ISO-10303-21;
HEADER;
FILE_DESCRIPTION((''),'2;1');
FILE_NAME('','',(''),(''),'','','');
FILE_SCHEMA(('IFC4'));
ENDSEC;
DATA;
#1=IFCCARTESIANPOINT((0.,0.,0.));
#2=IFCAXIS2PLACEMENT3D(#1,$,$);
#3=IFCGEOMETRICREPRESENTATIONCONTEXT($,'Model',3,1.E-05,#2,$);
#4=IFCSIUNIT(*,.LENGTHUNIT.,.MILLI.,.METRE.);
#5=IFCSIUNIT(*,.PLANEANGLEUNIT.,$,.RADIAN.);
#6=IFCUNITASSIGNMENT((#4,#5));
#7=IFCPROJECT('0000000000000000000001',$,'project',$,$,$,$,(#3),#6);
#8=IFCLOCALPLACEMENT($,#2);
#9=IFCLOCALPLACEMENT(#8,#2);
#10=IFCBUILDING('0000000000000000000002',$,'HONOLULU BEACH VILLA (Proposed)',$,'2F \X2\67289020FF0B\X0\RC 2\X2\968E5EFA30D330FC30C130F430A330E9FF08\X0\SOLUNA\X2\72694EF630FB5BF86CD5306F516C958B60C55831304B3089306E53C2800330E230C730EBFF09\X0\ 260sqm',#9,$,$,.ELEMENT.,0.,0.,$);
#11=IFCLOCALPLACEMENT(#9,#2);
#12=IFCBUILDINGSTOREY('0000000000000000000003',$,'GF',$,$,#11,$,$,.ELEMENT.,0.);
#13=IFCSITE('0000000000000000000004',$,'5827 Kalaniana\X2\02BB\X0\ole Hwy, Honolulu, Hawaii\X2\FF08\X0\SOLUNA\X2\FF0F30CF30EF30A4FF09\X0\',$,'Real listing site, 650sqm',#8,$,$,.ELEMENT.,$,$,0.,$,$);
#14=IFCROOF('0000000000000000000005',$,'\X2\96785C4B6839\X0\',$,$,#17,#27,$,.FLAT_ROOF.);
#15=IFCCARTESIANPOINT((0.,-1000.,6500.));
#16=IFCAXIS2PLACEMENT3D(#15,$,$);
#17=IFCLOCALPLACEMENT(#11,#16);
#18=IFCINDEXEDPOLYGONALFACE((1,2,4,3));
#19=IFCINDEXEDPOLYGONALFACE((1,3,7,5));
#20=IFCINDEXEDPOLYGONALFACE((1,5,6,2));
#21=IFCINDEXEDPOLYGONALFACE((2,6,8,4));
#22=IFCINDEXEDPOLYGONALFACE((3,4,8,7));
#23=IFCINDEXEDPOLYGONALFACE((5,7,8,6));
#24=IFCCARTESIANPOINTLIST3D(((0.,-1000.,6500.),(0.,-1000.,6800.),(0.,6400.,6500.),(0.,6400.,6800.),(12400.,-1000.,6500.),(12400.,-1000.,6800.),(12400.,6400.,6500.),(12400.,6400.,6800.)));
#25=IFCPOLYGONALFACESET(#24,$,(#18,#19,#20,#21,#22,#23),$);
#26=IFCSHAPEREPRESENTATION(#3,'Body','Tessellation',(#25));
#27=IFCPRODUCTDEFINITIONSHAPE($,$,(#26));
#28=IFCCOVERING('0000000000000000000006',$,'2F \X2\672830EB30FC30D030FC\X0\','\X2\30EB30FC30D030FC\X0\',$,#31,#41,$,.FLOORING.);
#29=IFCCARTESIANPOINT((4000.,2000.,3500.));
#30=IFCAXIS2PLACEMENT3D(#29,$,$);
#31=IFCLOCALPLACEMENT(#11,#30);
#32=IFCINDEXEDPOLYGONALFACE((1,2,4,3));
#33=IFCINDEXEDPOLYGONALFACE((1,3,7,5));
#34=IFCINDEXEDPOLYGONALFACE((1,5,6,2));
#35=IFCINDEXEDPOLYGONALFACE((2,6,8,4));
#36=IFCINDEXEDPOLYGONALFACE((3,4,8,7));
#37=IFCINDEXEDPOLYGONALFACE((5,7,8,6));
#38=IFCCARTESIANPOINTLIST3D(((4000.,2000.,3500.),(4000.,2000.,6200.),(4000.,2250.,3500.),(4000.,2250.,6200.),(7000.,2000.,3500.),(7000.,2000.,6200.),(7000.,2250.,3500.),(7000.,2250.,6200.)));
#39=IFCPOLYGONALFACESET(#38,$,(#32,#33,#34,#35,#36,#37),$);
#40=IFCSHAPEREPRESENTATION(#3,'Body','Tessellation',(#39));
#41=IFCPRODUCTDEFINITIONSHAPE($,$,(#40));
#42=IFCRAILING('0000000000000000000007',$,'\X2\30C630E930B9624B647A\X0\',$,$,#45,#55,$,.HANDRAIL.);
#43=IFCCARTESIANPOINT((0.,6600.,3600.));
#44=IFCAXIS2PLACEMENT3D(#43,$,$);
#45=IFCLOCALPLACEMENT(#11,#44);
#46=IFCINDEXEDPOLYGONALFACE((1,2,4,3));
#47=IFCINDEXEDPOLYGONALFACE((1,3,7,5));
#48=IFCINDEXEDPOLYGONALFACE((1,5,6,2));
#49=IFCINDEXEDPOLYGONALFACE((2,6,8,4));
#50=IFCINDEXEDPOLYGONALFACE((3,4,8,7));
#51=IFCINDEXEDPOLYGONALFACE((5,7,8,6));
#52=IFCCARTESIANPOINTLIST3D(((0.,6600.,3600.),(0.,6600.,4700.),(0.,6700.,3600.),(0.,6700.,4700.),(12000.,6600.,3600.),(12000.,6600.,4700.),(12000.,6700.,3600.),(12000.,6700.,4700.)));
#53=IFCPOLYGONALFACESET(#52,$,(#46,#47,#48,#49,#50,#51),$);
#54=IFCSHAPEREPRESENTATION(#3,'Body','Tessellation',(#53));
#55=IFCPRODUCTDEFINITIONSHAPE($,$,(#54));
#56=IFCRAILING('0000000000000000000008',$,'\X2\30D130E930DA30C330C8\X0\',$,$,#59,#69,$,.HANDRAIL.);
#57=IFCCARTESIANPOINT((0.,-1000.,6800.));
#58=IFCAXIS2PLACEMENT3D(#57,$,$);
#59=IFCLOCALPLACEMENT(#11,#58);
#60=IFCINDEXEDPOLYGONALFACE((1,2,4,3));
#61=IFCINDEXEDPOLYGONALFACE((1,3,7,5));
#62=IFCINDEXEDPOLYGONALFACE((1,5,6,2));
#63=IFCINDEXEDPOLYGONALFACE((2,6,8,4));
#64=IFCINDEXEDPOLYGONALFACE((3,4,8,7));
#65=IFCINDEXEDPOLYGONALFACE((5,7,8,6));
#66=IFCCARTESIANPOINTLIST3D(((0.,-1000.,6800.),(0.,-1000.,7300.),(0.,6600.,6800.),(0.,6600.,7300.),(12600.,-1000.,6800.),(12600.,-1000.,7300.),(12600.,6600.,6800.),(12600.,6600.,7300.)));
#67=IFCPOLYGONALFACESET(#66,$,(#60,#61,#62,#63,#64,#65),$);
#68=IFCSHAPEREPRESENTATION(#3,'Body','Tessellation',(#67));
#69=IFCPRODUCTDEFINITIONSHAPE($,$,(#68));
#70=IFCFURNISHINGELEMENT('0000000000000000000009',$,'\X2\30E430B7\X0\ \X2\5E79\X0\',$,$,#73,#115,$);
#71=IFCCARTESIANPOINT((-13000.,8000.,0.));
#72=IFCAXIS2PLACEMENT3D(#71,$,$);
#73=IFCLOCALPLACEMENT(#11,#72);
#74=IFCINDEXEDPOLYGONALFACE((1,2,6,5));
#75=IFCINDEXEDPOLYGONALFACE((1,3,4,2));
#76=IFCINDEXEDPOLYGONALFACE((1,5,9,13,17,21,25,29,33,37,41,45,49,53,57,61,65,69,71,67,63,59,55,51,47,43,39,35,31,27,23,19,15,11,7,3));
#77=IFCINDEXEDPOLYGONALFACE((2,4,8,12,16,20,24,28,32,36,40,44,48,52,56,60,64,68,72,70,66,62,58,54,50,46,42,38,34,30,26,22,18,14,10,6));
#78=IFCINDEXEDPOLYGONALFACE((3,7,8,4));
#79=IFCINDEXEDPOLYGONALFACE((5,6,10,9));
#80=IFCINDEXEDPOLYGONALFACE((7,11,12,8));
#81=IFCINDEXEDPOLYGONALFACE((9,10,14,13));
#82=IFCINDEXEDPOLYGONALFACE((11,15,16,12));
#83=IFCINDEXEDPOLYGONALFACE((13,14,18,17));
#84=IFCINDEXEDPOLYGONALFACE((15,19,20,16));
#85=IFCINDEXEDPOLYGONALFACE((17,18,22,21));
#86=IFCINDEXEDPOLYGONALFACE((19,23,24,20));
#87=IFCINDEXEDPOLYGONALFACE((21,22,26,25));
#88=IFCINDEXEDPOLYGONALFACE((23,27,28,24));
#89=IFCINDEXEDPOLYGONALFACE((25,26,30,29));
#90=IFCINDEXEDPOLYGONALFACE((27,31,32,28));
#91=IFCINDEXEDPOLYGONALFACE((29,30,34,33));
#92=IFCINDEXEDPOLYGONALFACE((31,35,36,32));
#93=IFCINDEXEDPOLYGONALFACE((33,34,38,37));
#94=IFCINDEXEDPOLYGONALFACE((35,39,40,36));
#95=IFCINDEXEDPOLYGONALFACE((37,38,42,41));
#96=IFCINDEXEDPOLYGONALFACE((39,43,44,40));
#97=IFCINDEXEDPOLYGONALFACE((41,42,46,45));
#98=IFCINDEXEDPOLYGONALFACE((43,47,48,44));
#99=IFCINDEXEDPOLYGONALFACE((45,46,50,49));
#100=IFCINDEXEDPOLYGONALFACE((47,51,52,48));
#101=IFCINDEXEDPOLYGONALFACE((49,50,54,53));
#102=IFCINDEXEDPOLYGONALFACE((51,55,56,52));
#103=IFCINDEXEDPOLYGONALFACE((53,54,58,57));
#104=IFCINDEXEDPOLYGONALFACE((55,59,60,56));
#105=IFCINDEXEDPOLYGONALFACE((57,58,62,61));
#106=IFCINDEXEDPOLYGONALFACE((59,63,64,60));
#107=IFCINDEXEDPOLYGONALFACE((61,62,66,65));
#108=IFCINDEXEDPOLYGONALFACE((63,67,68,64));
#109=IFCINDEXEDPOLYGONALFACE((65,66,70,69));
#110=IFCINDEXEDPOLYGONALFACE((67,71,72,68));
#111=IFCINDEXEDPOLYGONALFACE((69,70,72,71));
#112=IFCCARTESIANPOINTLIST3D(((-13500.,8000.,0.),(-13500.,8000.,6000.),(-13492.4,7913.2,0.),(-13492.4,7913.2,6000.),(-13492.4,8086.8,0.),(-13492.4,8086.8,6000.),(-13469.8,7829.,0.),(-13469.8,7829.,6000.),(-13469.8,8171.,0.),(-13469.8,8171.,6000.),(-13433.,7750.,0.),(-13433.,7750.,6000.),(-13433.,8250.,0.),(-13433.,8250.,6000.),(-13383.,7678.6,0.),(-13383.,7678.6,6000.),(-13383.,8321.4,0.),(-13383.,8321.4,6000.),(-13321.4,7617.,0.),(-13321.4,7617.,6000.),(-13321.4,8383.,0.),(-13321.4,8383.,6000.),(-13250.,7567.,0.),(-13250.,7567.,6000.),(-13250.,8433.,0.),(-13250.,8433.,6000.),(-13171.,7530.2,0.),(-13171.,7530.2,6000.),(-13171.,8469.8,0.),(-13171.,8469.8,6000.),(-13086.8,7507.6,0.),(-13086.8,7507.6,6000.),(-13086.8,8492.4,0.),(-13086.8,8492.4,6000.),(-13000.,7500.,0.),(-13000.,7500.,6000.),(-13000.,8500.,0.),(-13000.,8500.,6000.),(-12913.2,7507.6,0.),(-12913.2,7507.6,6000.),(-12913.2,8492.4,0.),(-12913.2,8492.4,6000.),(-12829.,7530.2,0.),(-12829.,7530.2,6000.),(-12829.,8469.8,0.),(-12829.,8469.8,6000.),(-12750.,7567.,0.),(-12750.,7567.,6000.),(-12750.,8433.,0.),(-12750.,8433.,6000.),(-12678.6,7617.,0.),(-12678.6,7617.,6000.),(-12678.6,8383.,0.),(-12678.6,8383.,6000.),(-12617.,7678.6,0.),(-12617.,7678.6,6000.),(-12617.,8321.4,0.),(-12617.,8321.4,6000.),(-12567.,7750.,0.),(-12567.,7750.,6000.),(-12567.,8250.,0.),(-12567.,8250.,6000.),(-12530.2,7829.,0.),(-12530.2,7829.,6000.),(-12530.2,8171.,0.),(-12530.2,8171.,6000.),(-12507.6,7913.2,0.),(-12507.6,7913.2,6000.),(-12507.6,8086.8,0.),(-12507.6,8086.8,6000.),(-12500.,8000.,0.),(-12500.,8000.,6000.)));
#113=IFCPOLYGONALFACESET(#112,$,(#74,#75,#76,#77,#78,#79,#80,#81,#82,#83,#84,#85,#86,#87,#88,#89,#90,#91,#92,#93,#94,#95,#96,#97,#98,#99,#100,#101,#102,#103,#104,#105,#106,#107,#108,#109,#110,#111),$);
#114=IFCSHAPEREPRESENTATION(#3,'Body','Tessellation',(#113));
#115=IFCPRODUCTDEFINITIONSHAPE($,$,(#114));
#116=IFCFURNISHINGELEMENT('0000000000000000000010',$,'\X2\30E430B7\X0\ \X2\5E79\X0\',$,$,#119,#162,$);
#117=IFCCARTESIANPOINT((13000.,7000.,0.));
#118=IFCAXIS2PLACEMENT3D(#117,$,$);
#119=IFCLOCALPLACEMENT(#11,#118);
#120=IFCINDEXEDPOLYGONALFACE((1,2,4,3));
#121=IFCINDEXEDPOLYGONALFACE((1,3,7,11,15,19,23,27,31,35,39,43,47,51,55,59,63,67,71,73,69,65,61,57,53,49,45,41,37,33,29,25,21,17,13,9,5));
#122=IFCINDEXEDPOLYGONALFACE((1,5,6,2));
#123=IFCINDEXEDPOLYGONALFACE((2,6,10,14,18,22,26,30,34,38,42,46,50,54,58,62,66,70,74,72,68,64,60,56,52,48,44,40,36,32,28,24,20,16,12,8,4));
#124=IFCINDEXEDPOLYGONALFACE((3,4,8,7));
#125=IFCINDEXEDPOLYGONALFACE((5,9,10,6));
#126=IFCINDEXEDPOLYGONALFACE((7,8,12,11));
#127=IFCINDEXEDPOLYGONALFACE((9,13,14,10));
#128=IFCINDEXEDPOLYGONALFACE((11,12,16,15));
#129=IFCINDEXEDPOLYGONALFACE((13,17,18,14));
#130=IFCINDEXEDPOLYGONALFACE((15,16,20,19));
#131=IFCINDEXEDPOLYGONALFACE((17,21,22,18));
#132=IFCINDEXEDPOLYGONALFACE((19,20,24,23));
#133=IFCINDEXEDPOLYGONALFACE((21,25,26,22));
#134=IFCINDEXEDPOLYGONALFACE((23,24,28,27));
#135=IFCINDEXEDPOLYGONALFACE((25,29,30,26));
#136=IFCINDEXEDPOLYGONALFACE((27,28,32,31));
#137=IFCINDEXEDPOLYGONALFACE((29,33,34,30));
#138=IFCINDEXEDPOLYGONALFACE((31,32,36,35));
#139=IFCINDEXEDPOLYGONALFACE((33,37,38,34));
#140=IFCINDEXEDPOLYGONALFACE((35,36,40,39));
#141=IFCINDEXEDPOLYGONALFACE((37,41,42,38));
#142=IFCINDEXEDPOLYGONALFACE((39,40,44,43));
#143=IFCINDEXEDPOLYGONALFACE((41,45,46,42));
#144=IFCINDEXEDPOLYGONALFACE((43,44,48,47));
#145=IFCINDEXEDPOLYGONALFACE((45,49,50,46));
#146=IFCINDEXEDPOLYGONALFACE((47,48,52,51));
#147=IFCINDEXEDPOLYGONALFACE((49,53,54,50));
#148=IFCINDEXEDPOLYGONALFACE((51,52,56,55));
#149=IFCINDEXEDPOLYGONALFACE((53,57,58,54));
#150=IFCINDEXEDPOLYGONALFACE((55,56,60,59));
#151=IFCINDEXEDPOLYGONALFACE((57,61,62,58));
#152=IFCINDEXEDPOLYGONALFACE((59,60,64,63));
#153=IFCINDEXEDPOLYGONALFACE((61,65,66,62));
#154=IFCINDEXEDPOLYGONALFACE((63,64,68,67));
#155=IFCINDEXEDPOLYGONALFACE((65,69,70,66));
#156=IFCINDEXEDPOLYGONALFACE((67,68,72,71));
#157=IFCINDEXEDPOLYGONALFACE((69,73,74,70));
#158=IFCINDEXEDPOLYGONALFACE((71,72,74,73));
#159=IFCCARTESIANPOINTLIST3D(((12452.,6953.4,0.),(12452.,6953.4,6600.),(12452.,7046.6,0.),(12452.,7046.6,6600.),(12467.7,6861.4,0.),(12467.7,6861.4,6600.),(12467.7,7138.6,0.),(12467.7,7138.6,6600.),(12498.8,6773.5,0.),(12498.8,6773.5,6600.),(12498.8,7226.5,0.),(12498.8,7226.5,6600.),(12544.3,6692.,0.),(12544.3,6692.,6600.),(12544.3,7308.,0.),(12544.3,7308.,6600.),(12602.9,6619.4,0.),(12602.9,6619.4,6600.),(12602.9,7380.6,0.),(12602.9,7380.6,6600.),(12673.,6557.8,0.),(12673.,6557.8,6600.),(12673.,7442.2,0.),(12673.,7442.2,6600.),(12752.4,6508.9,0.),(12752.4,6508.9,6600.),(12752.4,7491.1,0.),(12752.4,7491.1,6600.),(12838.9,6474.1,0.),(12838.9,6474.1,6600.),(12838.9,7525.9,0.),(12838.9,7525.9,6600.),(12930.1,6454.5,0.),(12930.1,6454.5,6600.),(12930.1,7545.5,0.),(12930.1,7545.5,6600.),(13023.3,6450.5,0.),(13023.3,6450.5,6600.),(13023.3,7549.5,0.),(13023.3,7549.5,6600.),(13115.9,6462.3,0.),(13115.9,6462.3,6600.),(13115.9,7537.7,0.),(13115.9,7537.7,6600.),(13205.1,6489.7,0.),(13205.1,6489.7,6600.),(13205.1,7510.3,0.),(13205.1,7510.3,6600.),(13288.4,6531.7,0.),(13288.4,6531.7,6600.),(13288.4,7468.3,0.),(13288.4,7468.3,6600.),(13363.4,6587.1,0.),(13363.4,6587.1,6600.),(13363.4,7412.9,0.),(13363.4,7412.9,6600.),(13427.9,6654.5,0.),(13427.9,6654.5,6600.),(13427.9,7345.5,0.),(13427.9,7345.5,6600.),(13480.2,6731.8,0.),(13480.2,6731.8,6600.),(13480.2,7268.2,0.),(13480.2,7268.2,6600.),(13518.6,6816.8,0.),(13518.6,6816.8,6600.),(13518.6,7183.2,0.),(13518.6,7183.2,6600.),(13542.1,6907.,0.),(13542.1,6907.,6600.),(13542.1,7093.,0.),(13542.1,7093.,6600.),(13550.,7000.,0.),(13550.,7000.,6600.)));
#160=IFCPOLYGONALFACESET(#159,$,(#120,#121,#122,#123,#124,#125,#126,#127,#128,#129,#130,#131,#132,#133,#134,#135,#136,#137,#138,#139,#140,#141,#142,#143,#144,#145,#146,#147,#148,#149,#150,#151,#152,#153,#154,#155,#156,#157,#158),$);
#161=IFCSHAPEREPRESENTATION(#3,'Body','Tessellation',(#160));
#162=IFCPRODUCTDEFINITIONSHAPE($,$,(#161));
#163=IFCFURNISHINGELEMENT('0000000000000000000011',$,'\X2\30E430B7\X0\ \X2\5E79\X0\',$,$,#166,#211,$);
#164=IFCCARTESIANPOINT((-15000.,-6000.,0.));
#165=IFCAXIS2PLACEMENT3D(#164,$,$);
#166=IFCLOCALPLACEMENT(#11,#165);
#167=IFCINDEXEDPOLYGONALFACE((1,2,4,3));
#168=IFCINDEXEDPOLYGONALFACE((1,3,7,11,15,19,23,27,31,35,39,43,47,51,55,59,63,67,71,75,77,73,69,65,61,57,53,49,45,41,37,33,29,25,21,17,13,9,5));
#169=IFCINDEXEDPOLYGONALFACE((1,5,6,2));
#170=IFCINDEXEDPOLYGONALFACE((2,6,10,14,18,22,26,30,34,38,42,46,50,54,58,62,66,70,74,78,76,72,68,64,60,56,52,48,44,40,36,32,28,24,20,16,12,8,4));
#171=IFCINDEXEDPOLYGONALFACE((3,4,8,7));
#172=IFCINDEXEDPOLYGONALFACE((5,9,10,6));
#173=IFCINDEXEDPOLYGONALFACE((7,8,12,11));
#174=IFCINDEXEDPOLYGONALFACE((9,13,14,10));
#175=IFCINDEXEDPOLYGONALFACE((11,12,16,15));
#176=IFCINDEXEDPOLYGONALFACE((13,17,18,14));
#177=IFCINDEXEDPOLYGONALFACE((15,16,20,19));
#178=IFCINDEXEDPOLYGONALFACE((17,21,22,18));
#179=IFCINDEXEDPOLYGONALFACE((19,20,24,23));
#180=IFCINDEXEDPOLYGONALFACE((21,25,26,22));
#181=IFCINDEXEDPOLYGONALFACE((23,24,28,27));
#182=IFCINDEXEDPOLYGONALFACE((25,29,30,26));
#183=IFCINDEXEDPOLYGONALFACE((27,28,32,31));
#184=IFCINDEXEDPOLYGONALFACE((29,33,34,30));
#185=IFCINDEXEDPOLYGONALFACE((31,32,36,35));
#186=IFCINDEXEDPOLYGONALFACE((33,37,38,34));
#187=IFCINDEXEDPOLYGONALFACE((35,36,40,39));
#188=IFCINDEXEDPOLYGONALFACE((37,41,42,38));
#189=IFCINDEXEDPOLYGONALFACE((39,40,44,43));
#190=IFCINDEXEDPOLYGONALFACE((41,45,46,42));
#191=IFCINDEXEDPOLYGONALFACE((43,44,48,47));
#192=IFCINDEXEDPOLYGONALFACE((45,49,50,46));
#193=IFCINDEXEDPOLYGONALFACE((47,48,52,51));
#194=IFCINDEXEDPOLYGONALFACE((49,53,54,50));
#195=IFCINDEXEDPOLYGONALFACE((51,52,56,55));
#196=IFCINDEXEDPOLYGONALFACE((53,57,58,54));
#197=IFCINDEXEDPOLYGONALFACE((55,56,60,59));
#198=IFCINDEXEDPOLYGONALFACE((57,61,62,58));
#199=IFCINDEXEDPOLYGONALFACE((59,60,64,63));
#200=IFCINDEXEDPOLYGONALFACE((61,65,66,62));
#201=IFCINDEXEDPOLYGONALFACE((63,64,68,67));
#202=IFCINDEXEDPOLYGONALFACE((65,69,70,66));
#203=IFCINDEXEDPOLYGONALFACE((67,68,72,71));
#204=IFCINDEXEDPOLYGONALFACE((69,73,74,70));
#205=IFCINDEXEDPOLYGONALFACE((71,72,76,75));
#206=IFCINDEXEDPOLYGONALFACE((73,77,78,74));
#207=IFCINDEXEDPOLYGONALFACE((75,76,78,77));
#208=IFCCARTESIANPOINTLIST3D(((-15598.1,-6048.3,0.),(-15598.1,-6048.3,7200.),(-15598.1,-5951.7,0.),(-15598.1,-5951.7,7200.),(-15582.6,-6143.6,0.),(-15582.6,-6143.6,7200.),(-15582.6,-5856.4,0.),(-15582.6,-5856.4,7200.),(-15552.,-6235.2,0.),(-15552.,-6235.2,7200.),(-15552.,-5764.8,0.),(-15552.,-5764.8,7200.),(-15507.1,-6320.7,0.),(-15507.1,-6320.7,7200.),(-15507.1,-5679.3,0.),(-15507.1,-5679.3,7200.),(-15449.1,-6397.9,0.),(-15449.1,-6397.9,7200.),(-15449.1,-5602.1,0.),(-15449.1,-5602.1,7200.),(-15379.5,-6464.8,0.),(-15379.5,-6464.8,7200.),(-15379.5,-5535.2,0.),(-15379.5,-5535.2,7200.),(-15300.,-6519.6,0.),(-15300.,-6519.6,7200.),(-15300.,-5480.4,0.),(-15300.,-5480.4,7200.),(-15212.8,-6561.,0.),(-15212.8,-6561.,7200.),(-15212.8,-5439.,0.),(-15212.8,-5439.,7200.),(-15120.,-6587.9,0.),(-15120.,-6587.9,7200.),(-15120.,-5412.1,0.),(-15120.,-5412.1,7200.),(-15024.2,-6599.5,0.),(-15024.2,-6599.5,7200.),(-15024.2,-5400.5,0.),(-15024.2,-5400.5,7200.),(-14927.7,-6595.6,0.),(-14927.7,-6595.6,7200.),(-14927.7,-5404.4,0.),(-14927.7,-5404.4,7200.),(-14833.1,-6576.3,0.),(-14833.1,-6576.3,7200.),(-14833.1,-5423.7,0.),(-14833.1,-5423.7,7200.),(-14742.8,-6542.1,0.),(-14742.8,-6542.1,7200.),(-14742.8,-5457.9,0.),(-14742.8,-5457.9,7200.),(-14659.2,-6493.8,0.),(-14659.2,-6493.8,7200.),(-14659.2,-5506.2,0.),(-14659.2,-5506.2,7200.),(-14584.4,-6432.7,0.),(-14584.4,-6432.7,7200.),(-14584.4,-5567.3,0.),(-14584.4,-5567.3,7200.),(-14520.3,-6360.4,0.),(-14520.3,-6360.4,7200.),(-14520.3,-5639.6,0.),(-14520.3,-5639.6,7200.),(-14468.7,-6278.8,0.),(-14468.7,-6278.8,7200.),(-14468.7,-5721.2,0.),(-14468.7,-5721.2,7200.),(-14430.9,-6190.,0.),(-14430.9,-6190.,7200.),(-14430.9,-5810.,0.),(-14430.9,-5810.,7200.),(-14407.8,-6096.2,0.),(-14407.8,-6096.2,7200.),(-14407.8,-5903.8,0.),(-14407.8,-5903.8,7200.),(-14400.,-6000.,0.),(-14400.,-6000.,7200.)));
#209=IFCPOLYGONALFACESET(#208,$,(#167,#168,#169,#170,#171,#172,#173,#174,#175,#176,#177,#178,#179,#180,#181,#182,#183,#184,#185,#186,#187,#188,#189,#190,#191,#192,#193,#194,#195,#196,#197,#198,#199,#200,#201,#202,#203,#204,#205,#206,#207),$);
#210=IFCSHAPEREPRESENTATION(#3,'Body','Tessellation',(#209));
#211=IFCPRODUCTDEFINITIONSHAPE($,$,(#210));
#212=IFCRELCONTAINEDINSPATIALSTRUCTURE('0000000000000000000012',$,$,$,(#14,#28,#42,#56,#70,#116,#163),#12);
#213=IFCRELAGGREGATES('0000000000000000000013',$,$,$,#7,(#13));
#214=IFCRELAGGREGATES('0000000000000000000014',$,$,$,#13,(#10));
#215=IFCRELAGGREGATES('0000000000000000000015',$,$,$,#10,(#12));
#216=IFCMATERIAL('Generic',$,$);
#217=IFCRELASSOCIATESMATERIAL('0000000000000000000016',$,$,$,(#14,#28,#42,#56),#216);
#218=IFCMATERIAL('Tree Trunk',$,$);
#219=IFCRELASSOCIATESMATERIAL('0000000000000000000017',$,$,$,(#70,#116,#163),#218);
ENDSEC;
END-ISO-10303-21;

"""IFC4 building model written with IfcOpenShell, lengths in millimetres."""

from ifc_helpers import new_model, si_unit, frame, frame_2d, origin, origin_2d, place, context, project, spatial, rectangle, circle, extrude, material, element, save


model = new_model("IFC4")

# Units and contexts
model_context = context("Model", 3, precision=1e-05, world=origin())
ifc_project = project(units=[si_unit("LENGTHUNIT", "METRE", prefix="MILLI"), si_unit("PLANEANGLEUNIT", "RADIAN")], contexts=[model_context])

# Site, building, storey
site_placement = place(None, origin())
site = spatial("IfcSite", under=ifc_project, at=site_placement, Name="5827 Kalanianaʻole Hwy, Honolulu, Hawaii（SOLUNA／ハワイ）", ObjectType="Real listing site, 650sqm", CompositionType="ELEMENT", RefElevation=0.0)
building_placement = place(site_placement, origin())
building = spatial("IfcBuilding", under=site, at=building_placement, Name="HONOLULU BEACH VILLA (Proposed)", ObjectType="2F 木造＋RC 2階建ビーチヴィラ（SOLUNA物件・寸法は公開情報からの参考モデル） 260sqm", CompositionType="ELEMENT", ElevationOfRefHeight=0.0, ElevationOfTerrain=0.0)
storey_placement = place(building_placement, origin())
storey = spatial("IfcBuildingStorey", under=building, at=storey_placement, Name="GF", CompositionType="ELEMENT", Elevation=0.0)

# Shared definitions
ifc_material_1 = material(Name="Generic")

# Roof
roof_placement = place(storey_placement, frame((0.0, -1000.0, 6500.0)))
element("IfcRoof", 1, at=roof_placement, inside=storey, material=ifc_material_1, Name="陸屋根", PredefinedType="FLAT_ROOF", context=model_context, shape_type="SweptSolid", body=[
    extrude(rectangle(XDim=12400.0, YDim=7400.0, at=frame_2d((6200.0, 3700.0))), frame((0.0, -1000.0, 6500.0)), (0.0, 0.0, 1.0), 300.0),
])

# Covering
covering_placement = place(storey_placement, frame((4000.0, 2000.0, 3500.0)))
element("IfcCovering", 2, at=covering_placement, inside=storey, material=ifc_material_1, Name="2F 木ルーバー", Description="ルーバー", PredefinedType="FLOORING", context=model_context, shape_type="SweptSolid", body=[
    extrude(rectangle(XDim=3000.0, YDim=250.0, at=frame_2d((1500.0, 125.0))), frame((4000.0, 2000.0, 3500.0)), (0.0, 0.0, 1.0), 2700.0),
])

# Railings
railing_1_placement = place(storey_placement, frame((0.0, 6600.0, 3600.0)))
element("IfcRailing", 3, at=railing_1_placement, inside=storey, material=ifc_material_1, Name="テラス手摺", PredefinedType="HANDRAIL", context=model_context, shape_type="SweptSolid", body=[
    extrude(rectangle(XDim=12000.0, YDim=100.0, at=frame_2d((6000.0, 50.0))), frame((0.0, 6600.0, 3600.0)), (0.0, 0.0, 1.0), 1100.0),
])
railing_2_placement = place(storey_placement, frame((0.0, -1000.0, 6800.0)))
element("IfcRailing", 4, at=railing_2_placement, inside=storey, material=ifc_material_1, Name="パラペット", PredefinedType="HANDRAIL", context=model_context, shape_type="SweptSolid", body=[
    extrude(rectangle(XDim=12600.0, YDim=7600.0, at=frame_2d((6300.0, 3800.0))), frame((0.0, -1000.0, 6800.0)), (0.0, 0.0, 1.0), 500.0),
])

# Furnishing elements
ifc_material_2 = material(Name="Tree Trunk")
furnishing_1_placement = place(storey_placement, frame((-13000.0, 8000.0, 0.0)))
element("IfcFurnishingElement", 5, at=furnishing_1_placement, inside=storey, material=ifc_material_2, Name="ヤシ 幹", context=model_context, shape_type="SweptSolid", body=[
    extrude(circle(Radius=500.0, at=origin_2d()), frame((-13000.0, 8000.0, 0.0)), (0.0, 0.0, 1.0), 6000.0),
])
furnishing_2_placement = place(storey_placement, frame((13000.0, 7000.0, 0.0)))
element("IfcFurnishingElement", 6, at=furnishing_2_placement, inside=storey, material=ifc_material_2, Name="ヤシ 幹", context=model_context, shape_type="SweptSolid", body=[
    extrude(circle(Radius=550.0, at=origin_2d()), frame((13000.0, 7000.0, 0.0)), (0.0, 0.0, 1.0), 6600.0),
])
furnishing_3_placement = place(storey_placement, frame((-15000.0, -6000.0, 0.0)))
element("IfcFurnishingElement", 7, at=furnishing_3_placement, inside=storey, material=ifc_material_2, Name="ヤシ 幹", context=model_context, shape_type="SweptSolid", body=[
    extrude(circle(Radius=600.0, at=origin_2d()), frame((-15000.0, -6000.0, 0.0)), (0.0, 0.0, 1.0), 7200.0),
])

save(model, "model.ifc")
